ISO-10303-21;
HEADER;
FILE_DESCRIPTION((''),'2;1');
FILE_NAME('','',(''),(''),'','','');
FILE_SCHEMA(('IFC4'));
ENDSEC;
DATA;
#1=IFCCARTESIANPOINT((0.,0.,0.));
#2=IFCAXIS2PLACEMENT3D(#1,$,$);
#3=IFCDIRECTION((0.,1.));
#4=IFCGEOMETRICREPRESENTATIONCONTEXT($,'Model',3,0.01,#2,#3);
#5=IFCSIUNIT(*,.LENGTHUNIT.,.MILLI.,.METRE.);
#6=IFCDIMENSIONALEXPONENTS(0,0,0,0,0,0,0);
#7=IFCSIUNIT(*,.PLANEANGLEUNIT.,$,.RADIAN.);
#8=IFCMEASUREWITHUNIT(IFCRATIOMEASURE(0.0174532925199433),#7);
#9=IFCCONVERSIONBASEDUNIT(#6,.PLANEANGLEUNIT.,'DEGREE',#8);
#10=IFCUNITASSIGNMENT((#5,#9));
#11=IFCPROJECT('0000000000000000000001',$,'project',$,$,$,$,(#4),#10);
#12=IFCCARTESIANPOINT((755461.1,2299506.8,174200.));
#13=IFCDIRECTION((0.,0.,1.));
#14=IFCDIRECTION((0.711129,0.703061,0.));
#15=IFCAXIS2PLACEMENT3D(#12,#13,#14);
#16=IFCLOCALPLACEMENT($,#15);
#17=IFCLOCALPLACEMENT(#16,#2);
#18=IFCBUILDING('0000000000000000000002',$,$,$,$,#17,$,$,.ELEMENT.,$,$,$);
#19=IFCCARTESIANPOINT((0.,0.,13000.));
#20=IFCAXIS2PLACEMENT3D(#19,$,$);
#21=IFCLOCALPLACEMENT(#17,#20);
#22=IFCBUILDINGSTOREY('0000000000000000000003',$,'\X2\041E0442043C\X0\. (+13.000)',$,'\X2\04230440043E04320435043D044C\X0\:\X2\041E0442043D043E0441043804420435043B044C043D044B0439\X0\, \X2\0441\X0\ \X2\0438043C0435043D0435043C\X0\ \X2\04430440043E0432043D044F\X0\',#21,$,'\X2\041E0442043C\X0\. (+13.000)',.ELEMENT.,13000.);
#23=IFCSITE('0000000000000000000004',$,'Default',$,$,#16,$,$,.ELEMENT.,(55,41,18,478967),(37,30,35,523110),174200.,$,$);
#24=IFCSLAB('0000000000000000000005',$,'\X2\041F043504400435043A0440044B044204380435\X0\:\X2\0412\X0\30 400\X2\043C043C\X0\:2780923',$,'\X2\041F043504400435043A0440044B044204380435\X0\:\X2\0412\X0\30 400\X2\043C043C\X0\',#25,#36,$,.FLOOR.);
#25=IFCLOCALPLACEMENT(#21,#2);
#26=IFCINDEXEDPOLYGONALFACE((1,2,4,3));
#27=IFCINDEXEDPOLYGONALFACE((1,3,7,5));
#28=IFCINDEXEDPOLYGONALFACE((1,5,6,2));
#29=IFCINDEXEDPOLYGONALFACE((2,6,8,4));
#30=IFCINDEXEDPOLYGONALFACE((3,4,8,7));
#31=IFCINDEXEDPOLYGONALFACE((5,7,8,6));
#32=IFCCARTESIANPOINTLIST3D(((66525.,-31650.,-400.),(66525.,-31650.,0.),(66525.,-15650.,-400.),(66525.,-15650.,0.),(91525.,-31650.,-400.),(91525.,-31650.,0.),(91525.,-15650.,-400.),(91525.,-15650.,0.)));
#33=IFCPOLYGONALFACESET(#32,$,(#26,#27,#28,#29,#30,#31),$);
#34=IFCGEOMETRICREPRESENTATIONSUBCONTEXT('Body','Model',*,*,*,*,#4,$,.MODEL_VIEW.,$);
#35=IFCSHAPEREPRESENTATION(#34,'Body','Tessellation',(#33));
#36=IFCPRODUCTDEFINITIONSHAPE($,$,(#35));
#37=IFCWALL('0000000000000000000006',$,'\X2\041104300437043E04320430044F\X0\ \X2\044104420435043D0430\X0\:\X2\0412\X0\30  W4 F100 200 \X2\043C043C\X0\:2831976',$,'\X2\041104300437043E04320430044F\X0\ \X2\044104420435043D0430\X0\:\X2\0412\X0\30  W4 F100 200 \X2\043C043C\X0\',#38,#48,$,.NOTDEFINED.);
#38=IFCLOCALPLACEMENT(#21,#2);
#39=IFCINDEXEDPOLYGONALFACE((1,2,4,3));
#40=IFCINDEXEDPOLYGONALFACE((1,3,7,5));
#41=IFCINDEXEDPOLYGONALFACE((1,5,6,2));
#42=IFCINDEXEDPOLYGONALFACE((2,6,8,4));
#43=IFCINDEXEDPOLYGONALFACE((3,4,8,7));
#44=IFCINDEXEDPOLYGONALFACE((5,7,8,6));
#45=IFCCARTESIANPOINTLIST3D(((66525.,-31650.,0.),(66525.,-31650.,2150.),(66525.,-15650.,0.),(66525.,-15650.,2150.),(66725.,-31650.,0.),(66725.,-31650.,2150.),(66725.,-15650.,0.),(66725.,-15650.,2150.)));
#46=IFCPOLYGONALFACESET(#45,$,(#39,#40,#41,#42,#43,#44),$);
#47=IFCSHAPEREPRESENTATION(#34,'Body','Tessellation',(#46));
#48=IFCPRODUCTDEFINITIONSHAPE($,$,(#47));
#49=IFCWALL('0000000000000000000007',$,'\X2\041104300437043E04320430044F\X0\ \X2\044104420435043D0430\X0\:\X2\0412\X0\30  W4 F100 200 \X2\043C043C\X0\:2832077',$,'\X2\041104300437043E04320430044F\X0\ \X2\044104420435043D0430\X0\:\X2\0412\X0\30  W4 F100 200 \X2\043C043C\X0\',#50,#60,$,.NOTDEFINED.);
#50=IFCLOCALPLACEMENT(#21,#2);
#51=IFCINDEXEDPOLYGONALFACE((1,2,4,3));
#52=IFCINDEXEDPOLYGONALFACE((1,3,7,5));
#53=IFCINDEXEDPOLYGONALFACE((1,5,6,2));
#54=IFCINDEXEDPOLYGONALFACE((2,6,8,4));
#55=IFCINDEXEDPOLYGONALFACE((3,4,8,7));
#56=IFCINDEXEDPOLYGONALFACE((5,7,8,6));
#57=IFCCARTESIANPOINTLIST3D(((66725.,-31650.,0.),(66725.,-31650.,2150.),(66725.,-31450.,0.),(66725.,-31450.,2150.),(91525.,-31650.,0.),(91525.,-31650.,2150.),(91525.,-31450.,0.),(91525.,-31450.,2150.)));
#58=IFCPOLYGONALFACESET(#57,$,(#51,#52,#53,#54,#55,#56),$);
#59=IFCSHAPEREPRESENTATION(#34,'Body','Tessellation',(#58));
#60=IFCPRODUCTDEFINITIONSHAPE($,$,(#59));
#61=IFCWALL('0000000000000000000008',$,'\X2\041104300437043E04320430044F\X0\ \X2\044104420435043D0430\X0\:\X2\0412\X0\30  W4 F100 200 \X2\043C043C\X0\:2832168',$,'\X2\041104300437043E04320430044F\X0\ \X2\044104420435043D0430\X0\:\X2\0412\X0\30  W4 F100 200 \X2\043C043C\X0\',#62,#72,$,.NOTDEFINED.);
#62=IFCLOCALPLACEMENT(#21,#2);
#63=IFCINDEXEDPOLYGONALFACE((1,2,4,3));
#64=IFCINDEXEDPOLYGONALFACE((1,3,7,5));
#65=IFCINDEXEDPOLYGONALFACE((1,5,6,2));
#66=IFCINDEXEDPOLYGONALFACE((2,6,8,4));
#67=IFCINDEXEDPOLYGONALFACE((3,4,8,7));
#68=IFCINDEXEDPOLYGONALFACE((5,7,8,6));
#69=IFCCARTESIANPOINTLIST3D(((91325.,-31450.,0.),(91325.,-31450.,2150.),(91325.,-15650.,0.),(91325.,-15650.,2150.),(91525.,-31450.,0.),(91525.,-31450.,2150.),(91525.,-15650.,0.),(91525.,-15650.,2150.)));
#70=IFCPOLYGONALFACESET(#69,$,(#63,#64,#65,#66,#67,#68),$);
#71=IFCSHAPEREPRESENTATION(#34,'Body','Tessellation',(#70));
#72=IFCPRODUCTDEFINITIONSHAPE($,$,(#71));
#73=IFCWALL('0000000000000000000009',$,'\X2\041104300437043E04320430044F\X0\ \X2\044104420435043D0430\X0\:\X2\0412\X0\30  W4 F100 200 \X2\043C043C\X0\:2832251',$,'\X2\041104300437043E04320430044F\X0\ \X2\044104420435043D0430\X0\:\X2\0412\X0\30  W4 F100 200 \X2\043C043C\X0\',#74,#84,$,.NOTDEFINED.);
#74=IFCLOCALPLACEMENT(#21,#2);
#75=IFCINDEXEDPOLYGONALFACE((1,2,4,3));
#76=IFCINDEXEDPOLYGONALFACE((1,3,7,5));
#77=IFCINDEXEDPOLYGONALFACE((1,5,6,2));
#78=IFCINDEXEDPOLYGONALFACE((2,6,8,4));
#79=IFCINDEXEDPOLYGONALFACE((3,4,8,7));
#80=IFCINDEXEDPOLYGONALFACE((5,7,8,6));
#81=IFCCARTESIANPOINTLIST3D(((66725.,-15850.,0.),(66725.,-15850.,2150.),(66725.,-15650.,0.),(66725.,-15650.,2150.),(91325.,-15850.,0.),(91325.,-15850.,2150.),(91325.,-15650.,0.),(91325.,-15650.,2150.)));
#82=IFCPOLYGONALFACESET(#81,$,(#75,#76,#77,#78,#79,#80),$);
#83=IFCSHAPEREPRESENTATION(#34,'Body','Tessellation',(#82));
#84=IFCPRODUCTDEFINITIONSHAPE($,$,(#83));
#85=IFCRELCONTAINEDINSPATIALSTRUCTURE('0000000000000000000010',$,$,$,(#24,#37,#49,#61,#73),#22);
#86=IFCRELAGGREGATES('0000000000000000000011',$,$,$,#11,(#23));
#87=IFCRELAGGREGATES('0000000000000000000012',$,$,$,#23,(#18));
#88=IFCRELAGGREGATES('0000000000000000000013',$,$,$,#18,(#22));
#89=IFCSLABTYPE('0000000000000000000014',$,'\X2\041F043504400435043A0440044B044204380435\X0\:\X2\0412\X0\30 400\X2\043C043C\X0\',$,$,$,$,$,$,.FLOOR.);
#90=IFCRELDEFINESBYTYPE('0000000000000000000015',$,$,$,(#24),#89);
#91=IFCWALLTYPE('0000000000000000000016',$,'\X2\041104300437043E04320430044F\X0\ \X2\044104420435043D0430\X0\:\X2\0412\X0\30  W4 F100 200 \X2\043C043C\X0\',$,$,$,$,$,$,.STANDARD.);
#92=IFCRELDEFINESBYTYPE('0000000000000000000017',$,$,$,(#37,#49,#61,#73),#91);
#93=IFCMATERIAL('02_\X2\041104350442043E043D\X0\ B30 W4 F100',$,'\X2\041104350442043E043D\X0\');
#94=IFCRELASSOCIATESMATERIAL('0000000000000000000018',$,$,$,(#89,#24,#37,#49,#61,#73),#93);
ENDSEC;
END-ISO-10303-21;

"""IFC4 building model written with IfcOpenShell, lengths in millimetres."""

from ifc_helpers import new_model, entity, si_unit, converted_unit, direction, frame, origin, place, context, subcontext, project, spatial, indexed_curve, outline, extrude, material, type_object, element, save


model = new_model("IFC4")

# Units and contexts
model_context = context("Model", 3, precision=0.01, world=origin(), true_north=direction((0.0, 1.0)))
body_context = subcontext(model_context, "Body", "Model", "MODEL_VIEW")
ifc_project = project(units=[si_unit("LENGTHUNIT", "METRE", prefix="MILLI"), converted_unit("PLANEANGLEUNIT", "DEGREE", entity("IfcRatioMeasure", 0.0174532925199433), si_unit("PLANEANGLEUNIT", "RADIAN"), dimensions=[0, 0, 0, 0, 0, 0, 0])], contexts=[model_context])

# Site, building, storey
site_placement = place(None, frame((755461.1, 2299506.8, 174200.0), z_axis=(0.0, 0.0, 1.0), x_axis=(0.711129, 0.703061, 0.0)))
site = spatial("IfcSite", under=ifc_project, at=site_placement, Name="Default", CompositionType="ELEMENT", RefLatitude=(55, 41, 18, 478967), RefLongitude=(37, 30, 35, 523110), RefElevation=174200.0)
building_placement = place(site_placement, origin())
building = spatial("IfcBuilding", under=site, at=building_placement, CompositionType="ELEMENT")
storey_placement = place(building_placement, frame((0.0, 0.0, 13000.0)))
storey = spatial("IfcBuildingStorey", under=building, at=storey_placement, Name="Отм. (+13.000)", ObjectType="Уровень:Относительный, с именем уровня", LongName="Отм. (+13.000)", CompositionType="ELEMENT", Elevation=13000.0)

# Shared definitions
ifc_material_1 = material(Name="02_Бетон B30 W4 F100", Category="Бетон")

# Slab
slab_type = type_object("IfcSlabType", Name="Перекрытие:В30 400мм", PredefinedType="FLOOR", material=ifc_material_1)
slab_placement = place(storey_placement, origin())
element("IfcSlab", 1, at=slab_placement, inside=storey, type_object=slab_type, material=ifc_material_1, Name="Перекрытие:В30 400мм:2780923", ObjectType="Перекрытие:В30 400мм", PredefinedType="FLOOR", context=body_context, shape_type="SweptSolid", body=[
    extrude(outline(indexed_curve([(-8000.0, -12500.0), (8000.0, -12500.0), (8000.0, 12500.0), (-8000.0, 12500.0), (-8000.0, -12500.0)], self_intersect=False)), frame((79025.0, -23650.0, 0.0), z_axis=(0.0, 0.0, -1.0), x_axis=(0.0, 1.0, 0.0)), (0.0, 0.0, 1.0), 400.0),
])

# Walls
wall_type = type_object("IfcWallType", Name="Базовая стена:В30  W4 F100 200 мм", PredefinedType="STANDARD")
wall_1_placement = place(storey_placement, frame((66625.0, -15650.0, 0.0), z_axis=(0.0, 0.0, 1.0), x_axis=(0.0, -1.0, 0.0)))
element("IfcWall", 2, at=wall_1_placement, inside=storey, type_object=wall_type, material=ifc_material_1, Name="Базовая стена:В30  W4 F100 200 мм:2831976", ObjectType="Базовая стена:В30  W4 F100 200 мм", PredefinedType="NOTDEFINED", context=body_context, shape_type="SweptSolid", body=[
    extrude(outline(indexed_curve([(16000.0, 100.0), (0.0, 100.0), (0.0, -100.0), (16000.0, -100.0), (16000.0, 100.0)], self_intersect=False)), origin(), (0.0, 0.0, 1.0), 2150.0),
])
wall_2_placement = place(storey_placement, frame((66725.0, -31550.0, 0.0)))
element("IfcWall", 3, at=wall_2_placement, inside=storey, type_object=wall_type, material=ifc_material_1, Name="Базовая стена:В30  W4 F100 200 мм:2832077", ObjectType="Базовая стена:В30  W4 F100 200 мм", PredefinedType="NOTDEFINED", context=body_context, shape_type="SweptSolid", body=[
    extrude(outline(indexed_curve([(24800.0, 100.0), (0.0, 100.0), (0.0, -100.0), (24800.0, -100.0), (24800.0, 100.0)], self_intersect=False)), origin(), (0.0, 0.0, 1.0), 2150.0),
])
wall_3_placement = place(storey_placement, frame((91425.0, -31450.0, 0.0), z_axis=(0.0, 0.0, 1.0), x_axis=(0.0, 1.0, 0.0)))
element("IfcWall", 4, at=wall_3_placement, inside=storey, type_object=wall_type, material=ifc_material_1, Name="Базовая стена:В30  W4 F100 200 мм:2832168", ObjectType="Базовая стена:В30  W4 F100 200 мм", PredefinedType="NOTDEFINED", context=body_context, shape_type="SweptSolid", body=[
    extrude(outline(indexed_curve([(15800.0, 100.0), (0.0, 100.0), (0.0, -100.0), (15800.0, -100.0), (15800.0, 100.0)], self_intersect=False)), origin(), (0.0, 0.0, 1.0), 2150.0),
])
wall_4_placement = place(storey_placement, frame((91325.0, -15750.0, 0.0), z_axis=(0.0, 0.0, 1.0), x_axis=(-1.0, 0.0, 0.0)))
element("IfcWall", 5, at=wall_4_placement, inside=storey, type_object=wall_type, material=ifc_material_1, Name="Базовая стена:В30  W4 F100 200 мм:2832251", ObjectType="Базовая стена:В30  W4 F100 200 мм", PredefinedType="NOTDEFINED", context=body_context, shape_type="SweptSolid", body=[
    extrude(outline(indexed_curve([(24600.0, 100.0), (0.0, 100.0), (0.0, -100.0), (24600.0, -100.0), (24600.0, 100.0)], self_intersect=False)), origin(), (0.0, 0.0, 1.0), 2150.0),
])

save(model, "model.ifc")
